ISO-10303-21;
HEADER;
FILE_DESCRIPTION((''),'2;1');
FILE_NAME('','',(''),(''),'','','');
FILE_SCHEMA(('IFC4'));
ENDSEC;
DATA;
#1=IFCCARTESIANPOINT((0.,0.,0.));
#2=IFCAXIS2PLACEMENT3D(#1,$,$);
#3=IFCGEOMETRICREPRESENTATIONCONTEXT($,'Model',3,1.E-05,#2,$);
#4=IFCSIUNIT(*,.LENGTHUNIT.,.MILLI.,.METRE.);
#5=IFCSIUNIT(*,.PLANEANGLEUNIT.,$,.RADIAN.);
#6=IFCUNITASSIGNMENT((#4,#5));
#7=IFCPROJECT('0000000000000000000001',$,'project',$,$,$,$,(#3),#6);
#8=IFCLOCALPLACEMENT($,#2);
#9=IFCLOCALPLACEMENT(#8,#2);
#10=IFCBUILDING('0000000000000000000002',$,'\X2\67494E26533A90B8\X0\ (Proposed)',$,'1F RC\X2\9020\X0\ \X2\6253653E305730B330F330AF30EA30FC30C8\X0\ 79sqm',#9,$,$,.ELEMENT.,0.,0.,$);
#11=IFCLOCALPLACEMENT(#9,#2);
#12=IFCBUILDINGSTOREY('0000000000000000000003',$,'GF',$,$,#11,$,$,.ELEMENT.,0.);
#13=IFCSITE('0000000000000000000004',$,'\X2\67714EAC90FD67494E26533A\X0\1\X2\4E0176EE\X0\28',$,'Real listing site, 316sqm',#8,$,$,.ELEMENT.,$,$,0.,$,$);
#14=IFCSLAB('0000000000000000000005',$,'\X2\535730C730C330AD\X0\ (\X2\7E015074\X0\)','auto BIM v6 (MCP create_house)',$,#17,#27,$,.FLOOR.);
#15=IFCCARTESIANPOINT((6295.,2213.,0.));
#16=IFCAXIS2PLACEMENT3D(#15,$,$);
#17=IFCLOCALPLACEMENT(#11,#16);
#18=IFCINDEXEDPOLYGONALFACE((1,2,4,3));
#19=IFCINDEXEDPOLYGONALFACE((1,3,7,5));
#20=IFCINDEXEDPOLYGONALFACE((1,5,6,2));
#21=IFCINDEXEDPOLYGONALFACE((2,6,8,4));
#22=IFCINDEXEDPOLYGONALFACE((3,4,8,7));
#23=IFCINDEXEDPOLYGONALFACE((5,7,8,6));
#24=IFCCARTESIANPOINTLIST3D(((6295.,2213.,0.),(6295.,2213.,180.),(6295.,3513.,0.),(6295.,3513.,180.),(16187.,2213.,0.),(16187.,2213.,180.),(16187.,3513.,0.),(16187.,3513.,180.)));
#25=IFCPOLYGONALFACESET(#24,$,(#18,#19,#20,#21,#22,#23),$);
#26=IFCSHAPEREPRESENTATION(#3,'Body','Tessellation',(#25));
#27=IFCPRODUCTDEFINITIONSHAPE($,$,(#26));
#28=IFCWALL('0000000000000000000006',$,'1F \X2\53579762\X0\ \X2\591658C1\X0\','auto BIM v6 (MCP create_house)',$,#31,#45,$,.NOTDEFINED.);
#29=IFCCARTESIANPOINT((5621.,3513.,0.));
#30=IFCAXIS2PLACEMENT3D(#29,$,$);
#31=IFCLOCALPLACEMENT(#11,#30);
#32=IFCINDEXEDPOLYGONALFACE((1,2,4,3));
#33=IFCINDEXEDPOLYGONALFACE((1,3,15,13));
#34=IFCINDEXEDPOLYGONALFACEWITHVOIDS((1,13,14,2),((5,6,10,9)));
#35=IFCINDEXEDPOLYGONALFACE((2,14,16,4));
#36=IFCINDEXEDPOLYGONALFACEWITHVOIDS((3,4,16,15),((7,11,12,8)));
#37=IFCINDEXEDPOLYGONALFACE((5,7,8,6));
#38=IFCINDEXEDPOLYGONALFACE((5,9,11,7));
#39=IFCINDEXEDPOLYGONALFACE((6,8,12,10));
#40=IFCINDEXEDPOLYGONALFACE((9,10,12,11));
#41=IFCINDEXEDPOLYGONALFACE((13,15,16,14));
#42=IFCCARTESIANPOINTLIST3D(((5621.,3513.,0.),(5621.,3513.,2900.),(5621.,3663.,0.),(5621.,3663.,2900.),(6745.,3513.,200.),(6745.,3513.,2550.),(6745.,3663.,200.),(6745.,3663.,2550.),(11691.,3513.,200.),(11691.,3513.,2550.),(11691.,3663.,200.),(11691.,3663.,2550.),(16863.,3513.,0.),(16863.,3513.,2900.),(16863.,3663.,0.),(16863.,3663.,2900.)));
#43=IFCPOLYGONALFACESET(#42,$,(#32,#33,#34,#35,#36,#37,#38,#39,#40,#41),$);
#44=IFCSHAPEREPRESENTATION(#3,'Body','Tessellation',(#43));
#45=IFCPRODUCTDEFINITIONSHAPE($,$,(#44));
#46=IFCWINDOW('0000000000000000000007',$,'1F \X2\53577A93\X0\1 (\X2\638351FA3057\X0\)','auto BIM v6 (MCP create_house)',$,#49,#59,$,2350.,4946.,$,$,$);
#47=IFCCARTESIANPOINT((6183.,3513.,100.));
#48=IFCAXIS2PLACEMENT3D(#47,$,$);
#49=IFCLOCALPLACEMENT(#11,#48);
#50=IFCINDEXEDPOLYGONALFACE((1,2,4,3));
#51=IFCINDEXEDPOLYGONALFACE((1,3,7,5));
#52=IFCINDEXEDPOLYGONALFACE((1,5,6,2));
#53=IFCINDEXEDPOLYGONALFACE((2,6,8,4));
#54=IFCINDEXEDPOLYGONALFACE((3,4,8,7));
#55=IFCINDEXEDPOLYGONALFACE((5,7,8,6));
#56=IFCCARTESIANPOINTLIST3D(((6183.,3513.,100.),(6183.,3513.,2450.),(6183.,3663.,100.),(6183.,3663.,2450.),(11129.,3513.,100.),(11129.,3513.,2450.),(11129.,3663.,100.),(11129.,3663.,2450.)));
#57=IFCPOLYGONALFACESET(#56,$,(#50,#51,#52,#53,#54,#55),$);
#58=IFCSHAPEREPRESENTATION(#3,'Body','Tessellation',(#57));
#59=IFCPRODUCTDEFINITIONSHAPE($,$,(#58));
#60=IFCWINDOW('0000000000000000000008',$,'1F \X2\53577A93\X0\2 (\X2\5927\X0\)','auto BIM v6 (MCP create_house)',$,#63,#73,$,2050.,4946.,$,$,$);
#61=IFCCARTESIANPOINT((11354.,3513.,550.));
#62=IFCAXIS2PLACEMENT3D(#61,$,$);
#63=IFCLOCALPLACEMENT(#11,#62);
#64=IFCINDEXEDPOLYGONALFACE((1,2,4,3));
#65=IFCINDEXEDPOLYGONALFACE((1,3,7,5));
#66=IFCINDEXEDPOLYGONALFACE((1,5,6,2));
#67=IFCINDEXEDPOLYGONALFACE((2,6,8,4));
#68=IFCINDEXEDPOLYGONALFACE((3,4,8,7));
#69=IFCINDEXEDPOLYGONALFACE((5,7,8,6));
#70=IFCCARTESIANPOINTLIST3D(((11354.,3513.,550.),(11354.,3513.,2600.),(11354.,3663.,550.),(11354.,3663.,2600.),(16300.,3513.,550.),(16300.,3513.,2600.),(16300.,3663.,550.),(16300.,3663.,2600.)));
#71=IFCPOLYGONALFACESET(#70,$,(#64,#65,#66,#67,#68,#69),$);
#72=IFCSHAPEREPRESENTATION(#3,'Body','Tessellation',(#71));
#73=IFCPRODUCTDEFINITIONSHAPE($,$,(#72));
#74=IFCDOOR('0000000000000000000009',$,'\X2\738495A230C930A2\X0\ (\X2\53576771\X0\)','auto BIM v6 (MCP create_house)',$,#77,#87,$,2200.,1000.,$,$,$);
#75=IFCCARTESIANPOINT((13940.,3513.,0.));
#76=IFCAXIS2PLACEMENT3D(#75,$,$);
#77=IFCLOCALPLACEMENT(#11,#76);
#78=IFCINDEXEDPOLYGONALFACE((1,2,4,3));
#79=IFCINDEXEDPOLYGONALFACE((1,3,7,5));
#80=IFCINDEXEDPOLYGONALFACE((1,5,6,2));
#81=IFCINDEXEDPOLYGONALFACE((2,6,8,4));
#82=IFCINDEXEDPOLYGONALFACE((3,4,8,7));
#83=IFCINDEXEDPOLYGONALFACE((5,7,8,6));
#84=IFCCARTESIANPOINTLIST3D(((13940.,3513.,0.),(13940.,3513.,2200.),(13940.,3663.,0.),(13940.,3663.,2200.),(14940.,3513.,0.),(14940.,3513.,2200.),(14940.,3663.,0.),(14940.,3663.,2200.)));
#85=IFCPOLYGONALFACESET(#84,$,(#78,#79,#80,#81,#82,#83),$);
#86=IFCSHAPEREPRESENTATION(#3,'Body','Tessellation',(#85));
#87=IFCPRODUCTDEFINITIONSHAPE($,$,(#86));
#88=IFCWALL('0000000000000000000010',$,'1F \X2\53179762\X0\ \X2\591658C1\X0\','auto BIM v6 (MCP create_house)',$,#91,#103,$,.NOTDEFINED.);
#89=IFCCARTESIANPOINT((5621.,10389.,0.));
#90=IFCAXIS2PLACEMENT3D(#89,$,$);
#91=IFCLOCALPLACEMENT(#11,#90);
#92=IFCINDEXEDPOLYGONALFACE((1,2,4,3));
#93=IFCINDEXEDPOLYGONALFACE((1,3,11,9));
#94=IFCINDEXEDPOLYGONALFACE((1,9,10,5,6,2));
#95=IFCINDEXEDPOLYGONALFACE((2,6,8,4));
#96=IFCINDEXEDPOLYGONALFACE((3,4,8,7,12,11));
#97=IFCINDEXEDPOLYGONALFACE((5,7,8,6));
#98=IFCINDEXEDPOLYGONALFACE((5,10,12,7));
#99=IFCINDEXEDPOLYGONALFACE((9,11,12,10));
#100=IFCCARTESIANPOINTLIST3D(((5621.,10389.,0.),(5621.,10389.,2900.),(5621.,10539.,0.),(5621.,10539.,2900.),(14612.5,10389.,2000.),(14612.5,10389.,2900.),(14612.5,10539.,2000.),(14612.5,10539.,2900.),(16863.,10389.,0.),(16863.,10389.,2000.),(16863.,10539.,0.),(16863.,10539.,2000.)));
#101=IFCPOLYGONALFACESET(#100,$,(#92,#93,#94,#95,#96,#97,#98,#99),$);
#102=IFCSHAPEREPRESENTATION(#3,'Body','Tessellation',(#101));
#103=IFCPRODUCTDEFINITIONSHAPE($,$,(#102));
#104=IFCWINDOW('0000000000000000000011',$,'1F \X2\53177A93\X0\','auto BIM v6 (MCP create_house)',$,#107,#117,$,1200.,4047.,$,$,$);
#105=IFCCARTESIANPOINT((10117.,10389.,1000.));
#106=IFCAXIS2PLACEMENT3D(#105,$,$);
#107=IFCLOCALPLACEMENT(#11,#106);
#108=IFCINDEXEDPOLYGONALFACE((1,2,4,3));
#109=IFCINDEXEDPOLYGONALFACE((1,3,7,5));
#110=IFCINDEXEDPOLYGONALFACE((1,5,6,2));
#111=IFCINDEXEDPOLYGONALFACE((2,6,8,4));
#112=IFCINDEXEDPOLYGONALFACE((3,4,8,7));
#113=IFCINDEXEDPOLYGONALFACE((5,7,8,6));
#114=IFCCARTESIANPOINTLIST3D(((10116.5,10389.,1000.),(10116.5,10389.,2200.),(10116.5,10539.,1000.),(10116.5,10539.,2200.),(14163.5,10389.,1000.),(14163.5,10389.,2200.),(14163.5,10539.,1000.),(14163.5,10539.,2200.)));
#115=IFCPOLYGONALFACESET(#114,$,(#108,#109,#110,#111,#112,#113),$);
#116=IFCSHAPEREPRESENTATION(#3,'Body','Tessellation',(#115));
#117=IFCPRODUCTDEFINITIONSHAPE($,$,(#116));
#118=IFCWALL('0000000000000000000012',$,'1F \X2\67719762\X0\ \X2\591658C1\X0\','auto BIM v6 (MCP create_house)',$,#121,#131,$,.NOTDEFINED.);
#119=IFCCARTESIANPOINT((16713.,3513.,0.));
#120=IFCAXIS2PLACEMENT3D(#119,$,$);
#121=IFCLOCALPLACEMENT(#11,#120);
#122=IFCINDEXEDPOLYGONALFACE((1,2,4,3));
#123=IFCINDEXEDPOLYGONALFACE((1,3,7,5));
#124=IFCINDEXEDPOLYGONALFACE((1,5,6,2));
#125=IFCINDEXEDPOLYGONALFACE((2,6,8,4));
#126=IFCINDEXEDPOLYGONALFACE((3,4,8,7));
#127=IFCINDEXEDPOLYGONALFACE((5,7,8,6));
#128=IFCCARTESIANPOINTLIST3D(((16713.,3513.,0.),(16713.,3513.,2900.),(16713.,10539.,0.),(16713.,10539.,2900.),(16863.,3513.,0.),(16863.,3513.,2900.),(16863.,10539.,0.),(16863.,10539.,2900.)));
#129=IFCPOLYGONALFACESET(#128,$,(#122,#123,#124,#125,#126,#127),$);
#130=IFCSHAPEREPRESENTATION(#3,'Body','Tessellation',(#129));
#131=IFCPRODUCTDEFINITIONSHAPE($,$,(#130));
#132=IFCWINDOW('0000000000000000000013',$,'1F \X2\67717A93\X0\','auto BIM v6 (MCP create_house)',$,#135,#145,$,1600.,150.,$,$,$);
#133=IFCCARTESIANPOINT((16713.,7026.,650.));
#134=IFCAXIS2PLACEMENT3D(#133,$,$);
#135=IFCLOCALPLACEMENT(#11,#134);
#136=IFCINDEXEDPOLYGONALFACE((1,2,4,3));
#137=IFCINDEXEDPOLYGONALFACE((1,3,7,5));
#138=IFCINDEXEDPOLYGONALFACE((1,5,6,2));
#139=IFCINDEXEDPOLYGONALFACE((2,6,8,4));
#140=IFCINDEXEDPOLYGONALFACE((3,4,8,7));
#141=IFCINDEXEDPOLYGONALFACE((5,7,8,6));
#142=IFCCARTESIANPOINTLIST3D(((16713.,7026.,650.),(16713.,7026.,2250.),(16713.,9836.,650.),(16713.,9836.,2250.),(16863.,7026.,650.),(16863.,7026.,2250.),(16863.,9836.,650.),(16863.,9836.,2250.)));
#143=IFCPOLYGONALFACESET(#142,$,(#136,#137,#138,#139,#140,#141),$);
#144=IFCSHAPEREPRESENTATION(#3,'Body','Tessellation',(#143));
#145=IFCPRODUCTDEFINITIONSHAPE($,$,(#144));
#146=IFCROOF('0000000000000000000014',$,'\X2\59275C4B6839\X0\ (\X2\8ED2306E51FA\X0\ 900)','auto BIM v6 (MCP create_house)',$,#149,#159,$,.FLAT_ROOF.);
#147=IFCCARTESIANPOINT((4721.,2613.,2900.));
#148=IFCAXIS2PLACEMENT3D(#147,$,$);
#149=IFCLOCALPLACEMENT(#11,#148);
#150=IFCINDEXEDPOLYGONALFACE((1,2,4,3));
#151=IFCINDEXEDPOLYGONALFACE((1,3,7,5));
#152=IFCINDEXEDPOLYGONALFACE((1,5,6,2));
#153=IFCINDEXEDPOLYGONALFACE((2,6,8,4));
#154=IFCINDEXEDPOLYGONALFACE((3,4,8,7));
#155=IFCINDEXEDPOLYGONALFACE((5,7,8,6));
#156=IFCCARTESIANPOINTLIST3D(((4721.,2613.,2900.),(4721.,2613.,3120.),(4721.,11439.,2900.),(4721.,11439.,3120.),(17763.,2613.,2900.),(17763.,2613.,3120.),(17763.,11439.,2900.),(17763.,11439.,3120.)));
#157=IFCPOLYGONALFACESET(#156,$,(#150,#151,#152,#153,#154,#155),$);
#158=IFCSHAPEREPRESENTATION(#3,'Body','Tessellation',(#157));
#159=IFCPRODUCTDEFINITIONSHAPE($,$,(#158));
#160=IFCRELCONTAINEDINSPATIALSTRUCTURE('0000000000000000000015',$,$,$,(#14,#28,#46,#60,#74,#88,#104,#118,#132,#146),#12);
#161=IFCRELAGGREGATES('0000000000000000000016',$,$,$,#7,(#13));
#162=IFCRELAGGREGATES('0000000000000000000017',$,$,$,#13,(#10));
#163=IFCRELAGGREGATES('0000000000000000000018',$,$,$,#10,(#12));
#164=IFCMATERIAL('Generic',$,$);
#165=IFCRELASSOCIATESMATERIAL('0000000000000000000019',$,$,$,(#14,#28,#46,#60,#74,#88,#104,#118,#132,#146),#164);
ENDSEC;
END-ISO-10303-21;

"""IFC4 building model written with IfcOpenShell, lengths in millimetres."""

from ifc_helpers import new_model, si_unit, frame, frame_2d, origin, place, context, project, spatial, rectangle, extrude, material, element, fill, save


model = new_model("IFC4")

# Units and contexts
model_context = context("Model", 3, precision=1e-05, world=origin())
ifc_project = project(units=[si_unit("LENGTHUNIT", "METRE", prefix="MILLI"), si_unit("PLANEANGLEUNIT", "RADIAN")], contexts=[model_context])

# Site, building, storey
site_placement = place(None, origin())
site = spatial("IfcSite", under=ifc_project, at=site_placement, Name="東京都杉並区1丁目28", ObjectType="Real listing site, 316sqm", CompositionType="ELEMENT", RefElevation=0.0)
building_placement = place(site_placement, origin())
building = spatial("IfcBuilding", under=site, at=building_placement, Name="杉並区邸 (Proposed)", ObjectType="1F RC造 打放しコンクリート 79sqm", CompositionType="ELEMENT", ElevationOfRefHeight=0.0, ElevationOfTerrain=0.0)
storey_placement = place(building_placement, origin())
storey = spatial("IfcBuildingStorey", under=building, at=storey_placement, Name="GF", CompositionType="ELEMENT", Elevation=0.0)

# Slab
ifc_material = material(Name="Generic")
slab_1_placement = place(storey_placement, frame((6295.0, 2213.0, 0.0)))
element("IfcSlab", 1, at=slab_1_placement, inside=storey, material=ifc_material, Name="南デッキ (縁側)", Description="auto BIM v6 (MCP create_house)", PredefinedType="FLOOR", context=model_context, shape_type="SweptSolid", body=[
    extrude(rectangle(XDim=9892.0, YDim=1300.0, at=frame_2d((4946.0, 650.0))), frame((6295.0, 2213.0, 0.0)), (0.0, 0.0, 1.0), 180.0),
])

# Wall, openings, windows, door
wall_1_placement = place(storey_placement, frame((5621.0, 3513.0, 0.0)))
wall_1 = element("IfcWall", 2, at=wall_1_placement, inside=storey, material=ifc_material, Name="1F 南面 外壁", Description="auto BIM v6 (MCP create_house)", PredefinedType="NOTDEFINED", context=model_context, shape_type="SweptSolid", body=[
    extrude(rectangle(XDim=11242.0, YDim=150.0, at=frame_2d((5621.0, 75.0))), frame((5621.0, 3513.0, 0.0)), (0.0, 0.0, 1.0), 2900.0),
])
opening_1_placement = place(storey_placement, frame((6183.0, 3513.0, 100.0)))
opening_1 = element("IfcOpeningElement", 3, at=opening_1_placement, cuts=wall_1, PredefinedType="NOTDEFINED", context=model_context, shape_type="SweptSolid", body=[
    extrude(rectangle(XDim=4946.0, YDim=150.0, at=frame_2d((2473.0, 75.0))), frame((6183.0, 3513.0, 100.0)), (0.0, 0.0, 1.0), 2350.0),
])
opening_2_placement = place(storey_placement, frame((11354.0, 3513.0, 550.0)))
opening_2 = element("IfcOpeningElement", 4, at=opening_2_placement, cuts=wall_1, PredefinedType="NOTDEFINED", context=model_context, shape_type="SweptSolid", body=[
    extrude(rectangle(XDim=4946.0, YDim=150.0, at=frame_2d((2473.0, 75.0))), frame((11354.0, 3513.0, 550.0)), (0.0, 0.0, 1.0), 2050.0),
])
opening_3_placement = place(storey_placement, frame((13940.0, 3513.0, 0.0)))
opening_3 = element("IfcOpeningElement", 5, at=opening_3_placement, cuts=wall_1, PredefinedType="NOTDEFINED", context=model_context, shape_type="SweptSolid", body=[
    extrude(rectangle(XDim=1000.0, YDim=150.0, at=frame_2d((500.0, 75.0))), frame((13940.0, 3513.0, 0.0)), (0.0, 0.0, 1.0), 2200.0),
])
window_1_placement = place(storey_placement, frame((6183.0, 3513.0, 100.0)))
window_1 = element("IfcWindow", 6, at=window_1_placement, inside=storey, material=ifc_material, Name="1F 南窓1 (掃出し)", Description="auto BIM v6 (MCP create_house)", OverallHeight=2350.0, OverallWidth=4946.0, context=model_context, shape_type="SweptSolid", body=[
    extrude(rectangle(XDim=4946.0, YDim=150.0, at=frame_2d((2473.0, 75.0))), frame((6183.0, 3513.0, 100.0)), (0.0, 0.0, 1.0), 2350.0),
])
fill(opening_1, window_1)
window_2_placement = place(storey_placement, frame((11354.0, 3513.0, 550.0)))
window_2 = element("IfcWindow", 7, at=window_2_placement, inside=storey, material=ifc_material, Name="1F 南窓2 (大)", Description="auto BIM v6 (MCP create_house)", OverallHeight=2050.0, OverallWidth=4946.0, context=model_context, shape_type="SweptSolid", body=[
    extrude(rectangle(XDim=4946.0, YDim=150.0, at=frame_2d((2473.0, 75.0))), frame((11354.0, 3513.0, 550.0)), (0.0, 0.0, 1.0), 2050.0),
])
fill(opening_2, window_2)
door_placement = place(storey_placement, frame((13940.0, 3513.0, 0.0)))
door = element("IfcDoor", 8, at=door_placement, inside=storey, material=ifc_material, Name="玄関ドア (南東)", Description="auto BIM v6 (MCP create_house)", OverallHeight=2200.0, OverallWidth=1000.0, context=model_context, shape_type="SweptSolid", body=[
    extrude(rectangle(XDim=1000.0, YDim=150.0, at=frame_2d((500.0, 75.0))), frame((13940.0, 3513.0, 0.0)), (0.0, 0.0, 1.0), 2200.0),
])
fill(opening_3, door)

# Walls, openings, windows
wall_2_placement = place(storey_placement, frame((5621.0, 10389.0, 0.0)))
wall_2 = element("IfcWall", 9, at=wall_2_placement, inside=storey, material=ifc_material, Name="1F 北面 外壁", Description="auto BIM v6 (MCP create_house)", PredefinedType="NOTDEFINED", context=model_context, shape_type="SweptSolid", body=[
    extrude(rectangle(XDim=11242.0, YDim=150.0, at=frame_2d((5621.0, 75.0))), frame((5621.0, 10389.0, 0.0)), (0.0, 0.0, 1.0), 2900.0),
])
opening_4_placement = place(storey_placement, frame((10117.0, 10389.0, 1000.0)))
opening_4 = element("IfcOpeningElement", 10, at=opening_4_placement, cuts=wall_2, PredefinedType="NOTDEFINED", context=model_context, shape_type="SweptSolid", body=[
    extrude(rectangle(XDim=4047.0, YDim=150.0, at=frame_2d((2023.0, 75.0))), frame((10117.0, 10389.0, 1000.0)), (0.0, 0.0, 1.0), 1200.0),
])
window_3_placement = place(storey_placement, frame((10117.0, 10389.0, 1000.0)))
window_3 = element("IfcWindow", 11, at=window_3_placement, inside=storey, material=ifc_material, Name="1F 北窓", Description="auto BIM v6 (MCP create_house)", OverallHeight=1200.0, OverallWidth=4047.0, context=model_context, shape_type="SweptSolid", body=[
    extrude(rectangle(XDim=4047.0, YDim=150.0, at=frame_2d((2023.0, 75.0))), frame((10117.0, 10389.0, 1000.0)), (0.0, 0.0, 1.0), 1200.0),
])
fill(opening_4, window_3)
wall_3_placement = place(storey_placement, frame((16713.0, 3513.0, 0.0)))
wall_3 = element("IfcWall", 12, at=wall_3_placement, inside=storey, material=ifc_material, Name="1F 東面 外壁", Description="auto BIM v6 (MCP create_house)", PredefinedType="NOTDEFINED", context=model_context, shape_type="SweptSolid", body=[
    extrude(rectangle(XDim=150.0, YDim=7026.0, at=frame_2d((75.0, 3513.0))), frame((16713.0, 3513.0, 0.0)), (0.0, 0.0, 1.0), 2900.0),
])
opening_5_placement = place(storey_placement, frame((16713.0, 7026.0, 650.0)))
opening_5 = element("IfcOpeningElement", 13, at=opening_5_placement, cuts=wall_3, PredefinedType="NOTDEFINED", context=model_context, shape_type="SweptSolid", body=[
    extrude(rectangle(XDim=150.0, YDim=2810.0, at=frame_2d((75.0, 1405.0))), frame((16713.0, 7026.0, 650.0)), (0.0, 0.0, 1.0), 1600.0),
])
window_4_placement = place(storey_placement, frame((16713.0, 7026.0, 650.0)))
window_4 = element("IfcWindow", 14, at=window_4_placement, inside=storey, material=ifc_material, Name="1F 東窓", Description="auto BIM v6 (MCP create_house)", OverallHeight=1600.0, OverallWidth=150.0, context=model_context, shape_type="SweptSolid", body=[
    extrude(rectangle(XDim=150.0, YDim=2810.0, at=frame_2d((75.0, 1405.0))), frame((16713.0, 7026.0, 650.0)), (0.0, 0.0, 1.0), 1600.0),
])
fill(opening_5, window_4)

# Roof
roof_1_placement = place(storey_placement, frame((4721.0, 2613.0, 2900.0)))
element("IfcRoof", 15, at=roof_1_placement, inside=storey, material=ifc_material, Name="大屋根 (軒の出 900)", Description="auto BIM v6 (MCP create_house)", PredefinedType="FLAT_ROOF", context=model_context, shape_type="SweptSolid", body=[
    extrude(rectangle(XDim=13042.0, YDim=8826.0, at=frame_2d((6521.0, 4413.0))), frame((4721.0, 2613.0, 2900.0)), (0.0, 0.0, 1.0), 220.0),
])

save(model, "model.ifc")
